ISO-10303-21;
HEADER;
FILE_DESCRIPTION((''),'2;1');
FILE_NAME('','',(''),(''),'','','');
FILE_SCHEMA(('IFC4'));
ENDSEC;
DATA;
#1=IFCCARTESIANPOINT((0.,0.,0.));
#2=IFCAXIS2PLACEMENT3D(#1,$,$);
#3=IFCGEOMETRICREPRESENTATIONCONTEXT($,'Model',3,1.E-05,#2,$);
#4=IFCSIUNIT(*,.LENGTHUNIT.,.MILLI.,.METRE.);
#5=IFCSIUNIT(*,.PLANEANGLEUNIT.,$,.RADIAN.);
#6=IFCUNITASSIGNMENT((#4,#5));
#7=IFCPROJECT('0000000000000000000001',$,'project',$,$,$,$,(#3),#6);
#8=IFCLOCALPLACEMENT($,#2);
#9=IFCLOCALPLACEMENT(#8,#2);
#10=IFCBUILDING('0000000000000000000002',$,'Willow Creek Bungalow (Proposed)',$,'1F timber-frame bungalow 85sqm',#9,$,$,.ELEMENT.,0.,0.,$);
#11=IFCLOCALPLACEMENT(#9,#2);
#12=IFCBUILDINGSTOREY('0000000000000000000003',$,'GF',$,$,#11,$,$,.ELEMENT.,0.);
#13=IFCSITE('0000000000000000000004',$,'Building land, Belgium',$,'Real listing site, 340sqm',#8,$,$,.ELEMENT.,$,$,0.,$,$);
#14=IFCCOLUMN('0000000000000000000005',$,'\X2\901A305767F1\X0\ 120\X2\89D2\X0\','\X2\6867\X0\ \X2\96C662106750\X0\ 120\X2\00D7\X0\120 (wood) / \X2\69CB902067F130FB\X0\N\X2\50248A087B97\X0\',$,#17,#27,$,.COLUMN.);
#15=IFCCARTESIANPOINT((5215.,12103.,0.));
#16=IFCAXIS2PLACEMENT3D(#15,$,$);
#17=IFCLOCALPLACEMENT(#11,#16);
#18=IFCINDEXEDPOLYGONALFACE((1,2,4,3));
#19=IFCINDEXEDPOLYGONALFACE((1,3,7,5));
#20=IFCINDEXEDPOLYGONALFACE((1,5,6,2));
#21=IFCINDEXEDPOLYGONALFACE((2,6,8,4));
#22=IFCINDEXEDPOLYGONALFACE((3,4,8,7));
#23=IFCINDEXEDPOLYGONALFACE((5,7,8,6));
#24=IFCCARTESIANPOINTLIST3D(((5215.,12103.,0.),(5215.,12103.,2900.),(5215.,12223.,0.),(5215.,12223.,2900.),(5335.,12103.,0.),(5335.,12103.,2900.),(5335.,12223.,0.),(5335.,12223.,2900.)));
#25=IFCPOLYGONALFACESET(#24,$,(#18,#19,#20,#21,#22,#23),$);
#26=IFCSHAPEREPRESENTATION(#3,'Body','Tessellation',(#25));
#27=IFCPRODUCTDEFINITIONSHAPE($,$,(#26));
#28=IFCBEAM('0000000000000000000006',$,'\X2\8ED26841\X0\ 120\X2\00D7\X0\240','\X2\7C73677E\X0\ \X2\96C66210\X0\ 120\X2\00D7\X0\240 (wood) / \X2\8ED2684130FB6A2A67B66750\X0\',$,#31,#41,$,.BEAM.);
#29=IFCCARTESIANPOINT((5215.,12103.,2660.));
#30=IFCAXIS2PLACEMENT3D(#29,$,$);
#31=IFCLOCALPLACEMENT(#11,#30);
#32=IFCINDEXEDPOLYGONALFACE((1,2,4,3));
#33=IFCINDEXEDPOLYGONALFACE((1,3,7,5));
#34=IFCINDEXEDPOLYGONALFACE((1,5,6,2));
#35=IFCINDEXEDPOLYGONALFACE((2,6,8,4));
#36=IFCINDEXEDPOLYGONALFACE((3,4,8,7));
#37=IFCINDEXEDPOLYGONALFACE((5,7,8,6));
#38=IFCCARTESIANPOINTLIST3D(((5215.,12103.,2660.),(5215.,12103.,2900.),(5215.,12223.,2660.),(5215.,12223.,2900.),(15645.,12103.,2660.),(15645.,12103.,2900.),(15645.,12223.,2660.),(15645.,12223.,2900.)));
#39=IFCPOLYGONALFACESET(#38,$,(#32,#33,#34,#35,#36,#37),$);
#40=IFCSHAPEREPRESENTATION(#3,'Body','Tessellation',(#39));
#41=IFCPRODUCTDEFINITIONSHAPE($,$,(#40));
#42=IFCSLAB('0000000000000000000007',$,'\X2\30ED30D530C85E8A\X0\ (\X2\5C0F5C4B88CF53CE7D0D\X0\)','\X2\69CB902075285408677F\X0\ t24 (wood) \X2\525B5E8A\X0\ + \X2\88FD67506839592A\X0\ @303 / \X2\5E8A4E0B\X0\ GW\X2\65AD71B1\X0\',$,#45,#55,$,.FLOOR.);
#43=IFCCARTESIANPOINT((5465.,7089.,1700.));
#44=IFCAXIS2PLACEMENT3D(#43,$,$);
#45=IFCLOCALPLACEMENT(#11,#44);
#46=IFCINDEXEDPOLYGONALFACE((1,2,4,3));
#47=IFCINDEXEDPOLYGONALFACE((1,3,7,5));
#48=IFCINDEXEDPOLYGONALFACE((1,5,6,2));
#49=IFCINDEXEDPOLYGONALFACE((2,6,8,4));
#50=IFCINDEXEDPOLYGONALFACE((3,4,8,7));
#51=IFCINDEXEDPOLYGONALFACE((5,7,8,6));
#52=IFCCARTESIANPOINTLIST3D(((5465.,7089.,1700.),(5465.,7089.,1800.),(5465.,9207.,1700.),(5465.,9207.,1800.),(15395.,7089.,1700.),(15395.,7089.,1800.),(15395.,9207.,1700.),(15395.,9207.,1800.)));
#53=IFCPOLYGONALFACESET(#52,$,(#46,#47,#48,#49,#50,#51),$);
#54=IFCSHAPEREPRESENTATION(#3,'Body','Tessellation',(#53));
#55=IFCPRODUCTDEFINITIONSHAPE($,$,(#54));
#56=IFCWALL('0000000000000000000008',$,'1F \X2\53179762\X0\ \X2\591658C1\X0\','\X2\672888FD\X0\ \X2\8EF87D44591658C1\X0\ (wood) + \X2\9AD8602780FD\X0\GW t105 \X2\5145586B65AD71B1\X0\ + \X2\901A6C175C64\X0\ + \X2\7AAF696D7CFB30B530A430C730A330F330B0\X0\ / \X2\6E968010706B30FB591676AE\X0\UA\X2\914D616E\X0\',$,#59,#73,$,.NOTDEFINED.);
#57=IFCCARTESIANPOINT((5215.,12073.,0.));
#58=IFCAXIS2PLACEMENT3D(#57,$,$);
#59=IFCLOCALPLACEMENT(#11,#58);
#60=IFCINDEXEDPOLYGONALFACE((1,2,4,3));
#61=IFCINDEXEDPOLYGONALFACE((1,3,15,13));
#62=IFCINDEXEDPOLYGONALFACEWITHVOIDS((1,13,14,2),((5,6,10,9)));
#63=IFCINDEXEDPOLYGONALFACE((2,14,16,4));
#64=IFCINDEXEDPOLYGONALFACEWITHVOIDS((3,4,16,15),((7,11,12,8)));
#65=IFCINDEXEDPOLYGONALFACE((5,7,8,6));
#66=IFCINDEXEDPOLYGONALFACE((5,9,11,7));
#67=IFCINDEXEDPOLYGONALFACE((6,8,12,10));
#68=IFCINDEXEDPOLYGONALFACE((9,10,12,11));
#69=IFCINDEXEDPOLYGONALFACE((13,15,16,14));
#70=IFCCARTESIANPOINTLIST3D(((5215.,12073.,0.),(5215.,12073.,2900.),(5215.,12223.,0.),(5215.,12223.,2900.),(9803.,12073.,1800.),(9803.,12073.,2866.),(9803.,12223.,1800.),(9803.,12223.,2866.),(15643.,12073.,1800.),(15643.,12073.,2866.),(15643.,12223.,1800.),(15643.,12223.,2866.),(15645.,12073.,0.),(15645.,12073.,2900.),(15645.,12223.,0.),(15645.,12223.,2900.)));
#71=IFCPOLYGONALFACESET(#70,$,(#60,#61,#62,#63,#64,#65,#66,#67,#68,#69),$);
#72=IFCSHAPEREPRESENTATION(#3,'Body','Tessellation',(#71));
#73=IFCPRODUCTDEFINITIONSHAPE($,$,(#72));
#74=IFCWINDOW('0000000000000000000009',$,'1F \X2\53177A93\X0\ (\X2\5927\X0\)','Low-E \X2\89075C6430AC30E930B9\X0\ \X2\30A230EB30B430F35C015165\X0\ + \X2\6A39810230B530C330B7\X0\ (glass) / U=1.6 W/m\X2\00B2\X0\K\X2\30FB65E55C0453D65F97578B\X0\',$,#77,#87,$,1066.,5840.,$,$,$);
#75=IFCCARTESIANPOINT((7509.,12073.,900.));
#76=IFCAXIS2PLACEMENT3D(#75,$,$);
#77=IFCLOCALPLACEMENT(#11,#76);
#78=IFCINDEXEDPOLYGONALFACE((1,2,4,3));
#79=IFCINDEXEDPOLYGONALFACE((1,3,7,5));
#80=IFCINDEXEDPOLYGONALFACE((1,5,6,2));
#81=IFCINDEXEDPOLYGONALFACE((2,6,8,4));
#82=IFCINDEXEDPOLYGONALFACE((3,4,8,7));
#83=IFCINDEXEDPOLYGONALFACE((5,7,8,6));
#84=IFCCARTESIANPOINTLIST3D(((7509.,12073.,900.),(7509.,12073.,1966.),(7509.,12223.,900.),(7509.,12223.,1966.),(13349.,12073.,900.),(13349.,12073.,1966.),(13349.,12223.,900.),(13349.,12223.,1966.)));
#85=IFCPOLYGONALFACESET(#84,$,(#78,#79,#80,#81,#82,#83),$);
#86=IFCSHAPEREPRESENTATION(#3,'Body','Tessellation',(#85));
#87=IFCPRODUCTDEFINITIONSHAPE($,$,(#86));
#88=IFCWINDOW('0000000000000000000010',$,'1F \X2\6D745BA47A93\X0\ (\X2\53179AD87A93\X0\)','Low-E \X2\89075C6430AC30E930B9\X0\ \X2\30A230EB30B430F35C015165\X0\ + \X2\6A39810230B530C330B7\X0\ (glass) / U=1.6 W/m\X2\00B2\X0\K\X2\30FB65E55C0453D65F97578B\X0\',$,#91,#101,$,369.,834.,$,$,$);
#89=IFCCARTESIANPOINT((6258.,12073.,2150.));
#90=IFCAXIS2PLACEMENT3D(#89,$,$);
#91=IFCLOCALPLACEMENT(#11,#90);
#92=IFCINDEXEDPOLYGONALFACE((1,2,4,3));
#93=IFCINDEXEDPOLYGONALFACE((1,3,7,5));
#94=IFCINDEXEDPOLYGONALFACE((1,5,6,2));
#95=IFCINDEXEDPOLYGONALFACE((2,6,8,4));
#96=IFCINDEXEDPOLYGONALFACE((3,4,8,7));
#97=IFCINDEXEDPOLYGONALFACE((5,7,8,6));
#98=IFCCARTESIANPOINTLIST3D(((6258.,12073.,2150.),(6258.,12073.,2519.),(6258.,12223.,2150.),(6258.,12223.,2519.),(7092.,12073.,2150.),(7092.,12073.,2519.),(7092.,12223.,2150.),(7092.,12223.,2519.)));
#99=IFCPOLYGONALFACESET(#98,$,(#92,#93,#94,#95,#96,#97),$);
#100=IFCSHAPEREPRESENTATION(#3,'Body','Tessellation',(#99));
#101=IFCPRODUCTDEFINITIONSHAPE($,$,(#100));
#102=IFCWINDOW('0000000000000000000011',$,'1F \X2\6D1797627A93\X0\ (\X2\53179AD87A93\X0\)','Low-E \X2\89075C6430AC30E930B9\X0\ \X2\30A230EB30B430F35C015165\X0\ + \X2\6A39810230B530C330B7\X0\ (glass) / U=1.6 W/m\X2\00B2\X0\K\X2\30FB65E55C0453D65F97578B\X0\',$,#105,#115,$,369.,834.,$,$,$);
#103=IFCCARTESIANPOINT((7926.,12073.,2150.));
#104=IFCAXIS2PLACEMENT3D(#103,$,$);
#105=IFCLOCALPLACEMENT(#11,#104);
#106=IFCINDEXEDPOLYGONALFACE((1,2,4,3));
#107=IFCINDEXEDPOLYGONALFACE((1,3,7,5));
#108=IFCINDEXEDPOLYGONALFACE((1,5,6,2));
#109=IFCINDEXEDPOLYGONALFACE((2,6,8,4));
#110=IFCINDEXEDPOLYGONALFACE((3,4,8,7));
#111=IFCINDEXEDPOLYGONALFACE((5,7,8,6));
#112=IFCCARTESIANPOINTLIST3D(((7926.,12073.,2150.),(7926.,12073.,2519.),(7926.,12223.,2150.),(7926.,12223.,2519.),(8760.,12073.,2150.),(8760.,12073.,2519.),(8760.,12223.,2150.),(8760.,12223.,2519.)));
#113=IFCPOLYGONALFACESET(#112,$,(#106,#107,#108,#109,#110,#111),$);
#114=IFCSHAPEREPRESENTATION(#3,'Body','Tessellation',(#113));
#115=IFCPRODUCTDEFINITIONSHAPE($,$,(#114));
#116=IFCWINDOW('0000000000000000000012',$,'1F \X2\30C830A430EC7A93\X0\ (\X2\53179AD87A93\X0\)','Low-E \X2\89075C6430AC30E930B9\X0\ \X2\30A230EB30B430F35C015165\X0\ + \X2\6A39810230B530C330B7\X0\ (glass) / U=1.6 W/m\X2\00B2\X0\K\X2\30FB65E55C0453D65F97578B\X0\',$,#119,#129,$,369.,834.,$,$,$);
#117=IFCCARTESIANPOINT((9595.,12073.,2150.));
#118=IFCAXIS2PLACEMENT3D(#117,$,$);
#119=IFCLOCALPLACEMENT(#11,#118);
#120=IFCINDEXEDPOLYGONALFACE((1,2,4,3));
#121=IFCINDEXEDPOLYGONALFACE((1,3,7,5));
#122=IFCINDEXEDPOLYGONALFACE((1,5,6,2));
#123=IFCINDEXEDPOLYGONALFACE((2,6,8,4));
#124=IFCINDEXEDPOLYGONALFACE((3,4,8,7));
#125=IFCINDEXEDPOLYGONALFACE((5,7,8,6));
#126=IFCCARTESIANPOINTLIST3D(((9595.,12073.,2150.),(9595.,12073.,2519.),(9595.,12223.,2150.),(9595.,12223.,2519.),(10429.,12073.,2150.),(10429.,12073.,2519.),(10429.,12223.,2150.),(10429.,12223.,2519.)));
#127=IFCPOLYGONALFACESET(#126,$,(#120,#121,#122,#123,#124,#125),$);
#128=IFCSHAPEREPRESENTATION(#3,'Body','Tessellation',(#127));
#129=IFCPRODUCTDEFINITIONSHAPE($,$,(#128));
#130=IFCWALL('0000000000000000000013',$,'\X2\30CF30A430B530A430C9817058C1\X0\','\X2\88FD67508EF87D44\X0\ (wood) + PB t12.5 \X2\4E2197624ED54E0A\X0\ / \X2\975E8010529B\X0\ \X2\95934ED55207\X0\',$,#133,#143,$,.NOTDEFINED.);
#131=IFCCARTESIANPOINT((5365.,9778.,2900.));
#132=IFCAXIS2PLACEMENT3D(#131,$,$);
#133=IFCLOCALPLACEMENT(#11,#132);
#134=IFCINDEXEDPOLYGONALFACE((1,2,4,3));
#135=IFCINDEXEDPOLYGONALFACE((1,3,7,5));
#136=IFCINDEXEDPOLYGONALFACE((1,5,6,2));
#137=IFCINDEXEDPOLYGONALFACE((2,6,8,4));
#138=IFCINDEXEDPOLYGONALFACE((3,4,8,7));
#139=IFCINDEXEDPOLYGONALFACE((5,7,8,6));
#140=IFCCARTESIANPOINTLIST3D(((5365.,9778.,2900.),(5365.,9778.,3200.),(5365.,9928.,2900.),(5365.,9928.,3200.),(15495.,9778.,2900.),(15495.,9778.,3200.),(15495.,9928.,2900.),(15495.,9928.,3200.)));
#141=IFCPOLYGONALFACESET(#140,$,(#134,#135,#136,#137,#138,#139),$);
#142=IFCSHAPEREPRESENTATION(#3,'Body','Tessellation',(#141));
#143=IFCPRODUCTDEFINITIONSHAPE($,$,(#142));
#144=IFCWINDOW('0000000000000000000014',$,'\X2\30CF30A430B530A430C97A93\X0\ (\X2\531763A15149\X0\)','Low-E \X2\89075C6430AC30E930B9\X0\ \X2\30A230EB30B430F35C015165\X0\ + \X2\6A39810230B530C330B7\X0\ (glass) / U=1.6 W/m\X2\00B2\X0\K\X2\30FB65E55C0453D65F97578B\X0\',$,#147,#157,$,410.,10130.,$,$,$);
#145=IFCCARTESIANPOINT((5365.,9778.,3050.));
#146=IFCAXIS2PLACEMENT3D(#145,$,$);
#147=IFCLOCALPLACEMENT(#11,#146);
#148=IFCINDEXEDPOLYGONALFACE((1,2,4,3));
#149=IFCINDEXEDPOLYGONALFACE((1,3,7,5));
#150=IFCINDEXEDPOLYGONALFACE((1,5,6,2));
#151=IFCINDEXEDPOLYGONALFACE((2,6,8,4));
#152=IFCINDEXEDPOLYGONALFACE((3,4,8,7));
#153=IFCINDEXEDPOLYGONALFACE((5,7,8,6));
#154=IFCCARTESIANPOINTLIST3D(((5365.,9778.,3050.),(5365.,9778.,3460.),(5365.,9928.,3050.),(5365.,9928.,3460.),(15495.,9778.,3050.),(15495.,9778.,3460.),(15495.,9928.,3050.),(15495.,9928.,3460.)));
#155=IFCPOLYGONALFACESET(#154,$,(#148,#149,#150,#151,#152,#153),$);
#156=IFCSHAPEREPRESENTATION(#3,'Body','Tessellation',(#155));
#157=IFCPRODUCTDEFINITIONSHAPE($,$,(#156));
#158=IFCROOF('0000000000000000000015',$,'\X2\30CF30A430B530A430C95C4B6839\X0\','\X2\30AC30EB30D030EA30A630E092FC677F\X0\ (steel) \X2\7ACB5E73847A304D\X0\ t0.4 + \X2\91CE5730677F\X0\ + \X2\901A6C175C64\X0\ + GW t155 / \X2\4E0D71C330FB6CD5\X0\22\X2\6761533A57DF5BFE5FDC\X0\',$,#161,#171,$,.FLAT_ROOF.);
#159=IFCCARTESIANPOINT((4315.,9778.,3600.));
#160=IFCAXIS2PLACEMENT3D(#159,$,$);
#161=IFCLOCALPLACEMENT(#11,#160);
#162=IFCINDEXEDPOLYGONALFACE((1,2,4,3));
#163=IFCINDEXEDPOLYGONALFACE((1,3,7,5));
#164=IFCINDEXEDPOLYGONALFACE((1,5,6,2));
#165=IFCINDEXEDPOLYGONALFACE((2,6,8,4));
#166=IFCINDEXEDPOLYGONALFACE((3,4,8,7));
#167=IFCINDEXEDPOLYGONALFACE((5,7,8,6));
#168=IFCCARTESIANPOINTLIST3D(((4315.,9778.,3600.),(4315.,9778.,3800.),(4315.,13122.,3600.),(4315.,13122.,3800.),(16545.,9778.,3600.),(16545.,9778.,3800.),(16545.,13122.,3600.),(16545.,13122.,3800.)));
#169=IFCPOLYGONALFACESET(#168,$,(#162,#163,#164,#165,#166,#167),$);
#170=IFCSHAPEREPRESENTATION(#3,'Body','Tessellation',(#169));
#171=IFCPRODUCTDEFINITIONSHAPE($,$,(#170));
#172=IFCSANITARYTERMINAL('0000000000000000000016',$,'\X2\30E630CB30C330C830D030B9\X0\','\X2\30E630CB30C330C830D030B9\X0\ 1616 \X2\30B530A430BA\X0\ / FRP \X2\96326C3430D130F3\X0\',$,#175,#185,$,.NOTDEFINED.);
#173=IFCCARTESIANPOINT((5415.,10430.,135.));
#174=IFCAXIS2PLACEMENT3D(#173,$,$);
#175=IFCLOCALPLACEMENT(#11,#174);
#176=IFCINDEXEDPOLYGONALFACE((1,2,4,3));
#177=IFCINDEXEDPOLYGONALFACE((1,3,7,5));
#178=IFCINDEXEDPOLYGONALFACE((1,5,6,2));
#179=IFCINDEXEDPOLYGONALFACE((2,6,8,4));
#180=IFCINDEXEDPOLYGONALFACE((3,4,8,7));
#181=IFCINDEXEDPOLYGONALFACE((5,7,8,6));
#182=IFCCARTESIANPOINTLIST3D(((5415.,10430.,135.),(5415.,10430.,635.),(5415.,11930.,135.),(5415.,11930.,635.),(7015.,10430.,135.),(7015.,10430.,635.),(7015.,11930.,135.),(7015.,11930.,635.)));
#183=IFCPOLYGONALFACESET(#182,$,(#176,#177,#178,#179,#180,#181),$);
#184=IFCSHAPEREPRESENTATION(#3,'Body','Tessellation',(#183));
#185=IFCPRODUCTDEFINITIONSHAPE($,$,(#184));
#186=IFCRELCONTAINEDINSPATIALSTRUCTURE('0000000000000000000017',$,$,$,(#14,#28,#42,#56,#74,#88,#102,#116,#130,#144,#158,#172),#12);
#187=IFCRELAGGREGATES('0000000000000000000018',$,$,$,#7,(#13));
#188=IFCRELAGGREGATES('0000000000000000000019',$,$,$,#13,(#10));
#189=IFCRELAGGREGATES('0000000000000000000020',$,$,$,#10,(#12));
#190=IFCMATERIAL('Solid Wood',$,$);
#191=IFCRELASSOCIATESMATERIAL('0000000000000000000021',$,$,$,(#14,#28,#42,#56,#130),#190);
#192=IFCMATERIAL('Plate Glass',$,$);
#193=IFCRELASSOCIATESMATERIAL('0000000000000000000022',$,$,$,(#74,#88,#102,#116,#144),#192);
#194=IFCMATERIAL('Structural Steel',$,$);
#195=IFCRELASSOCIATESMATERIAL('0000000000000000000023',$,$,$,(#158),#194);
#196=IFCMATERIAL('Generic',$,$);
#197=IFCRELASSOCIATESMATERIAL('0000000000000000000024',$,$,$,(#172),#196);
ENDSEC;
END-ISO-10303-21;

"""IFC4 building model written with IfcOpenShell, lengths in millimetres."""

from ifc_helpers import new_model, si_unit, frame, frame_2d, origin, place, context, project, spatial, rectangle, extrude, material, element, fill, save


model = new_model("IFC4")

# Units and contexts
model_context = context("Model", 3, precision=1e-05, world=origin())
ifc_project = project(units=[si_unit("LENGTHUNIT", "METRE", prefix="MILLI"), si_unit("PLANEANGLEUNIT", "RADIAN")], contexts=[model_context])

# Site, building, storey
site_placement = place(None, origin())
site = spatial("IfcSite", under=ifc_project, at=site_placement, Name="Building land, Belgium", ObjectType="Real listing site, 340sqm", CompositionType="ELEMENT", RefElevation=0.0)
building_placement = place(site_placement, origin())
building = spatial("IfcBuilding", under=site, at=building_placement, Name="Willow Creek Bungalow (Proposed)", ObjectType="1F timber-frame bungalow 85sqm", CompositionType="ELEMENT", ElevationOfRefHeight=0.0, ElevationOfTerrain=0.0)
storey_placement = place(building_placement, origin())
storey = spatial("IfcBuildingStorey", under=building, at=storey_placement, Name="GF", CompositionType="ELEMENT", Elevation=0.0)

# Column
ifc_material_1 = material(Name="Solid Wood")
column_1_placement = place(storey_placement, frame((5215.0, 12103.0, 0.0)))
element("IfcColumn", 1, at=column_1_placement, inside=storey, material=ifc_material_1, Name="通し柱 120角", Description="桧 集成材 120×120 (wood) / 構造柱・N値計算", PredefinedType="COLUMN", context=model_context, shape_type="SweptSolid", body=[
    extrude(rectangle(XDim=120.0, YDim=120.0, at=frame_2d((60.0, 60.0))), frame((5215.0, 12103.0, 0.0)), (0.0, 0.0, 1.0), 2900.0),
])

# Beam
beam_1_placement = place(storey_placement, frame((5215.0, 12103.0, 2660.0)))
element("IfcBeam", 2, at=beam_1_placement, inside=storey, material=ifc_material_1, Name="軒桁 120×240", Description="米松 集成 120×240 (wood) / 軒桁・横架材", PredefinedType="BEAM", context=model_context, shape_type="SweptSolid", body=[
    extrude(rectangle(XDim=10430.0, YDim=120.0, at=frame_2d((5215.0, 60.0))), frame((5215.0, 12103.0, 2660.0)), (0.0, 0.0, 1.0), 240.0),
])

# Slab
slab_placement = place(storey_placement, frame((5465.0, 7089.0, 1700.0)))
element("IfcSlab", 3, at=slab_placement, inside=storey, material=ifc_material_1, Name="ロフト床 (小屋裏収納)", Description="構造用合板 t24 (wood) 剛床 + 製材根太 @303 / 床下 GW断熱", PredefinedType="FLOOR", context=model_context, shape_type="SweptSolid", body=[
    extrude(rectangle(XDim=9930.0, YDim=2118.0, at=frame_2d((4965.0, 1059.0))), frame((5465.0, 7089.0, 1700.0)), (0.0, 0.0, 1.0), 100.0),
])

# Wall, openings, windows
wall_1_placement = place(storey_placement, frame((5215.0, 12073.0, 0.0)))
wall_1 = element("IfcWall", 4, at=wall_1_placement, inside=storey, material=ifc_material_1, Name="1F 北面 外壁", Description="木製 軸組外壁 (wood) + 高性能GW t105 充填断熱 + 通気層 + 窯業系サイディング / 準耐火・外皮UA配慮", PredefinedType="NOTDEFINED", context=model_context, shape_type="SweptSolid", body=[
    extrude(rectangle(XDim=10430.0, YDim=150.0, at=frame_2d((5215.0, 75.0))), frame((5215.0, 12073.0, 0.0)), (0.0, 0.0, 1.0), 2900.0),
])
opening_1_placement = place(storey_placement, frame((7509.0, 12073.0, 900.0)))
opening_1 = element("IfcOpeningElement", 5, at=opening_1_placement, cuts=wall_1, PredefinedType="NOTDEFINED", context=model_context, shape_type="SweptSolid", body=[
    extrude(rectangle(XDim=5840.0, YDim=150.0, at=frame_2d((2920.0, 75.0))), frame((7509.0, 12073.0, 900.0)), (0.0, 0.0, 1.0), 1066.0),
])
opening_2_placement = place(storey_placement, frame((6258.0, 12073.0, 2150.0)))
opening_2 = element("IfcOpeningElement", 6, at=opening_2_placement, cuts=wall_1, PredefinedType="NOTDEFINED", context=model_context, shape_type="SweptSolid", body=[
    extrude(rectangle(XDim=834.0, YDim=150.0, at=frame_2d((417.0, 75.0))), frame((6258.0, 12073.0, 2150.0)), (0.0, 0.0, 1.0), 369.0),
])
opening_3_placement = place(storey_placement, frame((7926.0, 12073.0, 2150.0)))
opening_3 = element("IfcOpeningElement", 7, at=opening_3_placement, cuts=wall_1, PredefinedType="NOTDEFINED", context=model_context, shape_type="SweptSolid", body=[
    extrude(rectangle(XDim=834.0, YDim=150.0, at=frame_2d((417.0, 75.0))), frame((7926.0, 12073.0, 2150.0)), (0.0, 0.0, 1.0), 369.0),
])
opening_4_placement = place(storey_placement, frame((9595.0, 12073.0, 2150.0)))
opening_4 = element("IfcOpeningElement", 8, at=opening_4_placement, cuts=wall_1, PredefinedType="NOTDEFINED", context=model_context, shape_type="SweptSolid", body=[
    extrude(rectangle(XDim=834.0, YDim=150.0, at=frame_2d((417.0, 75.0))), frame((9595.0, 12073.0, 2150.0)), (0.0, 0.0, 1.0), 369.0),
])
ifc_material_2 = material(Name="Plate Glass")
window_1_placement = place(storey_placement, frame((7509.0, 12073.0, 900.0)))
window_1 = element("IfcWindow", 9, at=window_1_placement, inside=storey, material=ifc_material_2, Name="1F 北窓 (大)", Description="Low-E 複層ガラス アルゴン封入 + 樹脂サッシ (glass) / U=1.6 W/m²K・日射取得型", OverallHeight=1066.0, OverallWidth=5840.0, context=model_context, shape_type="SweptSolid", body=[
    extrude(rectangle(XDim=5840.0, YDim=150.0, at=frame_2d((2920.0, 75.0))), frame((7509.0, 12073.0, 900.0)), (0.0, 0.0, 1.0), 1066.0),
])
fill(opening_1, window_1)
window_2_placement = place(storey_placement, frame((6258.0, 12073.0, 2150.0)))
window_2 = element("IfcWindow", 10, at=window_2_placement, inside=storey, material=ifc_material_2, Name="1F 浴室窓 (北高窓)", Description="Low-E 複層ガラス アルゴン封入 + 樹脂サッシ (glass) / U=1.6 W/m²K・日射取得型", OverallHeight=369.0, OverallWidth=834.0, context=model_context, shape_type="SweptSolid", body=[
    extrude(rectangle(XDim=834.0, YDim=150.0, at=frame_2d((417.0, 75.0))), frame((6258.0, 12073.0, 2150.0)), (0.0, 0.0, 1.0), 369.0),
])
fill(opening_2, window_2)
window_3_placement = place(storey_placement, frame((7926.0, 12073.0, 2150.0)))
window_3 = element("IfcWindow", 11, at=window_3_placement, inside=storey, material=ifc_material_2, Name="1F 洗面窓 (北高窓)", Description="Low-E 複層ガラス アルゴン封入 + 樹脂サッシ (glass) / U=1.6 W/m²K・日射取得型", OverallHeight=369.0, OverallWidth=834.0, context=model_context, shape_type="SweptSolid", body=[
    extrude(rectangle(XDim=834.0, YDim=150.0, at=frame_2d((417.0, 75.0))), frame((7926.0, 12073.0, 2150.0)), (0.0, 0.0, 1.0), 369.0),
])
fill(opening_3, window_3)
window_4_placement = place(storey_placement, frame((9595.0, 12073.0, 2150.0)))
window_4 = element("IfcWindow", 12, at=window_4_placement, inside=storey, material=ifc_material_2, Name="1F トイレ窓 (北高窓)", Description="Low-E 複層ガラス アルゴン封入 + 樹脂サッシ (glass) / U=1.6 W/m²K・日射取得型", OverallHeight=369.0, OverallWidth=834.0, context=model_context, shape_type="SweptSolid", body=[
    extrude(rectangle(XDim=834.0, YDim=150.0, at=frame_2d((417.0, 75.0))), frame((9595.0, 12073.0, 2150.0)), (0.0, 0.0, 1.0), 369.0),
])
fill(opening_4, window_4)

# Wall, opening, window
wall_2_placement = place(storey_placement, frame((5365.0, 9778.0, 2900.0)))
wall_2 = element("IfcWall", 13, at=wall_2_placement, inside=storey, material=ifc_material_1, Name="ハイサイド腰壁", Description="製材軸組 (wood) + PB t12.5 両面仕上 / 非耐力 間仕切", PredefinedType="NOTDEFINED", context=model_context, shape_type="SweptSolid", body=[
    extrude(rectangle(XDim=10130.0, YDim=150.0, at=frame_2d((5065.0, 75.0))), frame((5365.0, 9778.0, 2900.0)), (0.0, 0.0, 1.0), 700.0),
])
opening_5_placement = place(storey_placement, frame((5365.0, 9778.0, 3050.0)))
opening_5 = element("IfcOpeningElement", 14, at=opening_5_placement, cuts=wall_2, PredefinedType="NOTDEFINED", context=model_context, shape_type="SweptSolid", body=[
    extrude(rectangle(XDim=10130.0, YDim=150.0, at=frame_2d((5065.0, 75.0))), frame((5365.0, 9778.0, 3050.0)), (0.0, 0.0, 1.0), 410.0),
])
window_5_placement = place(storey_placement, frame((5365.0, 9778.0, 3050.0)))
window_5 = element("IfcWindow", 15, at=window_5_placement, inside=storey, material=ifc_material_2, Name="ハイサイド窓 (北採光)", Description="Low-E 複層ガラス アルゴン封入 + 樹脂サッシ (glass) / U=1.6 W/m²K・日射取得型", OverallHeight=410.0, OverallWidth=10130.0, context=model_context, shape_type="SweptSolid", body=[
    extrude(rectangle(XDim=10130.0, YDim=150.0, at=frame_2d((5065.0, 75.0))), frame((5365.0, 9778.0, 3050.0)), (0.0, 0.0, 1.0), 410.0),
])
fill(opening_5, window_5)

# Roof
ifc_material_3 = material(Name="Structural Steel")
roof_placement = place(storey_placement, frame((4315.0, 9778.0, 3600.0)))
element("IfcRoof", 16, at=roof_placement, inside=storey, material=ifc_material_3, Name="ハイサイド屋根", Description="ガルバリウム鋼板 (steel) 立平葺き t0.4 + 野地板 + 通気層 + GW t155 / 不燃・法22条区域対応", PredefinedType="FLAT_ROOF", context=model_context, shape_type="SweptSolid", body=[
    extrude(rectangle(XDim=12230.0, YDim=3344.0, at=frame_2d((6115.0, 1672.0))), frame((4315.0, 9778.0, 3600.0)), (0.0, 0.0, 1.0), 200.0),
])

# Sanitary terminal
ifc_material_4 = material(Name="Generic")
sanitary_terminal_placement = place(storey_placement, frame((5415.0, 10430.0, 135.0)))
element("IfcSanitaryTerminal", 17, at=sanitary_terminal_placement, inside=storey, material=ifc_material_4, Name="ユニットバス", Description="ユニットバス 1616 サイズ / FRP 防水パン", PredefinedType="NOTDEFINED", context=model_context, shape_type="SweptSolid", body=[
    extrude(rectangle(XDim=1600.0, YDim=1500.0, at=frame_2d((800.0, 750.0))), frame((5415.0, 10430.0, 135.0)), (0.0, 0.0, 1.0), 500.0),
])

save(model, "model.ifc")
